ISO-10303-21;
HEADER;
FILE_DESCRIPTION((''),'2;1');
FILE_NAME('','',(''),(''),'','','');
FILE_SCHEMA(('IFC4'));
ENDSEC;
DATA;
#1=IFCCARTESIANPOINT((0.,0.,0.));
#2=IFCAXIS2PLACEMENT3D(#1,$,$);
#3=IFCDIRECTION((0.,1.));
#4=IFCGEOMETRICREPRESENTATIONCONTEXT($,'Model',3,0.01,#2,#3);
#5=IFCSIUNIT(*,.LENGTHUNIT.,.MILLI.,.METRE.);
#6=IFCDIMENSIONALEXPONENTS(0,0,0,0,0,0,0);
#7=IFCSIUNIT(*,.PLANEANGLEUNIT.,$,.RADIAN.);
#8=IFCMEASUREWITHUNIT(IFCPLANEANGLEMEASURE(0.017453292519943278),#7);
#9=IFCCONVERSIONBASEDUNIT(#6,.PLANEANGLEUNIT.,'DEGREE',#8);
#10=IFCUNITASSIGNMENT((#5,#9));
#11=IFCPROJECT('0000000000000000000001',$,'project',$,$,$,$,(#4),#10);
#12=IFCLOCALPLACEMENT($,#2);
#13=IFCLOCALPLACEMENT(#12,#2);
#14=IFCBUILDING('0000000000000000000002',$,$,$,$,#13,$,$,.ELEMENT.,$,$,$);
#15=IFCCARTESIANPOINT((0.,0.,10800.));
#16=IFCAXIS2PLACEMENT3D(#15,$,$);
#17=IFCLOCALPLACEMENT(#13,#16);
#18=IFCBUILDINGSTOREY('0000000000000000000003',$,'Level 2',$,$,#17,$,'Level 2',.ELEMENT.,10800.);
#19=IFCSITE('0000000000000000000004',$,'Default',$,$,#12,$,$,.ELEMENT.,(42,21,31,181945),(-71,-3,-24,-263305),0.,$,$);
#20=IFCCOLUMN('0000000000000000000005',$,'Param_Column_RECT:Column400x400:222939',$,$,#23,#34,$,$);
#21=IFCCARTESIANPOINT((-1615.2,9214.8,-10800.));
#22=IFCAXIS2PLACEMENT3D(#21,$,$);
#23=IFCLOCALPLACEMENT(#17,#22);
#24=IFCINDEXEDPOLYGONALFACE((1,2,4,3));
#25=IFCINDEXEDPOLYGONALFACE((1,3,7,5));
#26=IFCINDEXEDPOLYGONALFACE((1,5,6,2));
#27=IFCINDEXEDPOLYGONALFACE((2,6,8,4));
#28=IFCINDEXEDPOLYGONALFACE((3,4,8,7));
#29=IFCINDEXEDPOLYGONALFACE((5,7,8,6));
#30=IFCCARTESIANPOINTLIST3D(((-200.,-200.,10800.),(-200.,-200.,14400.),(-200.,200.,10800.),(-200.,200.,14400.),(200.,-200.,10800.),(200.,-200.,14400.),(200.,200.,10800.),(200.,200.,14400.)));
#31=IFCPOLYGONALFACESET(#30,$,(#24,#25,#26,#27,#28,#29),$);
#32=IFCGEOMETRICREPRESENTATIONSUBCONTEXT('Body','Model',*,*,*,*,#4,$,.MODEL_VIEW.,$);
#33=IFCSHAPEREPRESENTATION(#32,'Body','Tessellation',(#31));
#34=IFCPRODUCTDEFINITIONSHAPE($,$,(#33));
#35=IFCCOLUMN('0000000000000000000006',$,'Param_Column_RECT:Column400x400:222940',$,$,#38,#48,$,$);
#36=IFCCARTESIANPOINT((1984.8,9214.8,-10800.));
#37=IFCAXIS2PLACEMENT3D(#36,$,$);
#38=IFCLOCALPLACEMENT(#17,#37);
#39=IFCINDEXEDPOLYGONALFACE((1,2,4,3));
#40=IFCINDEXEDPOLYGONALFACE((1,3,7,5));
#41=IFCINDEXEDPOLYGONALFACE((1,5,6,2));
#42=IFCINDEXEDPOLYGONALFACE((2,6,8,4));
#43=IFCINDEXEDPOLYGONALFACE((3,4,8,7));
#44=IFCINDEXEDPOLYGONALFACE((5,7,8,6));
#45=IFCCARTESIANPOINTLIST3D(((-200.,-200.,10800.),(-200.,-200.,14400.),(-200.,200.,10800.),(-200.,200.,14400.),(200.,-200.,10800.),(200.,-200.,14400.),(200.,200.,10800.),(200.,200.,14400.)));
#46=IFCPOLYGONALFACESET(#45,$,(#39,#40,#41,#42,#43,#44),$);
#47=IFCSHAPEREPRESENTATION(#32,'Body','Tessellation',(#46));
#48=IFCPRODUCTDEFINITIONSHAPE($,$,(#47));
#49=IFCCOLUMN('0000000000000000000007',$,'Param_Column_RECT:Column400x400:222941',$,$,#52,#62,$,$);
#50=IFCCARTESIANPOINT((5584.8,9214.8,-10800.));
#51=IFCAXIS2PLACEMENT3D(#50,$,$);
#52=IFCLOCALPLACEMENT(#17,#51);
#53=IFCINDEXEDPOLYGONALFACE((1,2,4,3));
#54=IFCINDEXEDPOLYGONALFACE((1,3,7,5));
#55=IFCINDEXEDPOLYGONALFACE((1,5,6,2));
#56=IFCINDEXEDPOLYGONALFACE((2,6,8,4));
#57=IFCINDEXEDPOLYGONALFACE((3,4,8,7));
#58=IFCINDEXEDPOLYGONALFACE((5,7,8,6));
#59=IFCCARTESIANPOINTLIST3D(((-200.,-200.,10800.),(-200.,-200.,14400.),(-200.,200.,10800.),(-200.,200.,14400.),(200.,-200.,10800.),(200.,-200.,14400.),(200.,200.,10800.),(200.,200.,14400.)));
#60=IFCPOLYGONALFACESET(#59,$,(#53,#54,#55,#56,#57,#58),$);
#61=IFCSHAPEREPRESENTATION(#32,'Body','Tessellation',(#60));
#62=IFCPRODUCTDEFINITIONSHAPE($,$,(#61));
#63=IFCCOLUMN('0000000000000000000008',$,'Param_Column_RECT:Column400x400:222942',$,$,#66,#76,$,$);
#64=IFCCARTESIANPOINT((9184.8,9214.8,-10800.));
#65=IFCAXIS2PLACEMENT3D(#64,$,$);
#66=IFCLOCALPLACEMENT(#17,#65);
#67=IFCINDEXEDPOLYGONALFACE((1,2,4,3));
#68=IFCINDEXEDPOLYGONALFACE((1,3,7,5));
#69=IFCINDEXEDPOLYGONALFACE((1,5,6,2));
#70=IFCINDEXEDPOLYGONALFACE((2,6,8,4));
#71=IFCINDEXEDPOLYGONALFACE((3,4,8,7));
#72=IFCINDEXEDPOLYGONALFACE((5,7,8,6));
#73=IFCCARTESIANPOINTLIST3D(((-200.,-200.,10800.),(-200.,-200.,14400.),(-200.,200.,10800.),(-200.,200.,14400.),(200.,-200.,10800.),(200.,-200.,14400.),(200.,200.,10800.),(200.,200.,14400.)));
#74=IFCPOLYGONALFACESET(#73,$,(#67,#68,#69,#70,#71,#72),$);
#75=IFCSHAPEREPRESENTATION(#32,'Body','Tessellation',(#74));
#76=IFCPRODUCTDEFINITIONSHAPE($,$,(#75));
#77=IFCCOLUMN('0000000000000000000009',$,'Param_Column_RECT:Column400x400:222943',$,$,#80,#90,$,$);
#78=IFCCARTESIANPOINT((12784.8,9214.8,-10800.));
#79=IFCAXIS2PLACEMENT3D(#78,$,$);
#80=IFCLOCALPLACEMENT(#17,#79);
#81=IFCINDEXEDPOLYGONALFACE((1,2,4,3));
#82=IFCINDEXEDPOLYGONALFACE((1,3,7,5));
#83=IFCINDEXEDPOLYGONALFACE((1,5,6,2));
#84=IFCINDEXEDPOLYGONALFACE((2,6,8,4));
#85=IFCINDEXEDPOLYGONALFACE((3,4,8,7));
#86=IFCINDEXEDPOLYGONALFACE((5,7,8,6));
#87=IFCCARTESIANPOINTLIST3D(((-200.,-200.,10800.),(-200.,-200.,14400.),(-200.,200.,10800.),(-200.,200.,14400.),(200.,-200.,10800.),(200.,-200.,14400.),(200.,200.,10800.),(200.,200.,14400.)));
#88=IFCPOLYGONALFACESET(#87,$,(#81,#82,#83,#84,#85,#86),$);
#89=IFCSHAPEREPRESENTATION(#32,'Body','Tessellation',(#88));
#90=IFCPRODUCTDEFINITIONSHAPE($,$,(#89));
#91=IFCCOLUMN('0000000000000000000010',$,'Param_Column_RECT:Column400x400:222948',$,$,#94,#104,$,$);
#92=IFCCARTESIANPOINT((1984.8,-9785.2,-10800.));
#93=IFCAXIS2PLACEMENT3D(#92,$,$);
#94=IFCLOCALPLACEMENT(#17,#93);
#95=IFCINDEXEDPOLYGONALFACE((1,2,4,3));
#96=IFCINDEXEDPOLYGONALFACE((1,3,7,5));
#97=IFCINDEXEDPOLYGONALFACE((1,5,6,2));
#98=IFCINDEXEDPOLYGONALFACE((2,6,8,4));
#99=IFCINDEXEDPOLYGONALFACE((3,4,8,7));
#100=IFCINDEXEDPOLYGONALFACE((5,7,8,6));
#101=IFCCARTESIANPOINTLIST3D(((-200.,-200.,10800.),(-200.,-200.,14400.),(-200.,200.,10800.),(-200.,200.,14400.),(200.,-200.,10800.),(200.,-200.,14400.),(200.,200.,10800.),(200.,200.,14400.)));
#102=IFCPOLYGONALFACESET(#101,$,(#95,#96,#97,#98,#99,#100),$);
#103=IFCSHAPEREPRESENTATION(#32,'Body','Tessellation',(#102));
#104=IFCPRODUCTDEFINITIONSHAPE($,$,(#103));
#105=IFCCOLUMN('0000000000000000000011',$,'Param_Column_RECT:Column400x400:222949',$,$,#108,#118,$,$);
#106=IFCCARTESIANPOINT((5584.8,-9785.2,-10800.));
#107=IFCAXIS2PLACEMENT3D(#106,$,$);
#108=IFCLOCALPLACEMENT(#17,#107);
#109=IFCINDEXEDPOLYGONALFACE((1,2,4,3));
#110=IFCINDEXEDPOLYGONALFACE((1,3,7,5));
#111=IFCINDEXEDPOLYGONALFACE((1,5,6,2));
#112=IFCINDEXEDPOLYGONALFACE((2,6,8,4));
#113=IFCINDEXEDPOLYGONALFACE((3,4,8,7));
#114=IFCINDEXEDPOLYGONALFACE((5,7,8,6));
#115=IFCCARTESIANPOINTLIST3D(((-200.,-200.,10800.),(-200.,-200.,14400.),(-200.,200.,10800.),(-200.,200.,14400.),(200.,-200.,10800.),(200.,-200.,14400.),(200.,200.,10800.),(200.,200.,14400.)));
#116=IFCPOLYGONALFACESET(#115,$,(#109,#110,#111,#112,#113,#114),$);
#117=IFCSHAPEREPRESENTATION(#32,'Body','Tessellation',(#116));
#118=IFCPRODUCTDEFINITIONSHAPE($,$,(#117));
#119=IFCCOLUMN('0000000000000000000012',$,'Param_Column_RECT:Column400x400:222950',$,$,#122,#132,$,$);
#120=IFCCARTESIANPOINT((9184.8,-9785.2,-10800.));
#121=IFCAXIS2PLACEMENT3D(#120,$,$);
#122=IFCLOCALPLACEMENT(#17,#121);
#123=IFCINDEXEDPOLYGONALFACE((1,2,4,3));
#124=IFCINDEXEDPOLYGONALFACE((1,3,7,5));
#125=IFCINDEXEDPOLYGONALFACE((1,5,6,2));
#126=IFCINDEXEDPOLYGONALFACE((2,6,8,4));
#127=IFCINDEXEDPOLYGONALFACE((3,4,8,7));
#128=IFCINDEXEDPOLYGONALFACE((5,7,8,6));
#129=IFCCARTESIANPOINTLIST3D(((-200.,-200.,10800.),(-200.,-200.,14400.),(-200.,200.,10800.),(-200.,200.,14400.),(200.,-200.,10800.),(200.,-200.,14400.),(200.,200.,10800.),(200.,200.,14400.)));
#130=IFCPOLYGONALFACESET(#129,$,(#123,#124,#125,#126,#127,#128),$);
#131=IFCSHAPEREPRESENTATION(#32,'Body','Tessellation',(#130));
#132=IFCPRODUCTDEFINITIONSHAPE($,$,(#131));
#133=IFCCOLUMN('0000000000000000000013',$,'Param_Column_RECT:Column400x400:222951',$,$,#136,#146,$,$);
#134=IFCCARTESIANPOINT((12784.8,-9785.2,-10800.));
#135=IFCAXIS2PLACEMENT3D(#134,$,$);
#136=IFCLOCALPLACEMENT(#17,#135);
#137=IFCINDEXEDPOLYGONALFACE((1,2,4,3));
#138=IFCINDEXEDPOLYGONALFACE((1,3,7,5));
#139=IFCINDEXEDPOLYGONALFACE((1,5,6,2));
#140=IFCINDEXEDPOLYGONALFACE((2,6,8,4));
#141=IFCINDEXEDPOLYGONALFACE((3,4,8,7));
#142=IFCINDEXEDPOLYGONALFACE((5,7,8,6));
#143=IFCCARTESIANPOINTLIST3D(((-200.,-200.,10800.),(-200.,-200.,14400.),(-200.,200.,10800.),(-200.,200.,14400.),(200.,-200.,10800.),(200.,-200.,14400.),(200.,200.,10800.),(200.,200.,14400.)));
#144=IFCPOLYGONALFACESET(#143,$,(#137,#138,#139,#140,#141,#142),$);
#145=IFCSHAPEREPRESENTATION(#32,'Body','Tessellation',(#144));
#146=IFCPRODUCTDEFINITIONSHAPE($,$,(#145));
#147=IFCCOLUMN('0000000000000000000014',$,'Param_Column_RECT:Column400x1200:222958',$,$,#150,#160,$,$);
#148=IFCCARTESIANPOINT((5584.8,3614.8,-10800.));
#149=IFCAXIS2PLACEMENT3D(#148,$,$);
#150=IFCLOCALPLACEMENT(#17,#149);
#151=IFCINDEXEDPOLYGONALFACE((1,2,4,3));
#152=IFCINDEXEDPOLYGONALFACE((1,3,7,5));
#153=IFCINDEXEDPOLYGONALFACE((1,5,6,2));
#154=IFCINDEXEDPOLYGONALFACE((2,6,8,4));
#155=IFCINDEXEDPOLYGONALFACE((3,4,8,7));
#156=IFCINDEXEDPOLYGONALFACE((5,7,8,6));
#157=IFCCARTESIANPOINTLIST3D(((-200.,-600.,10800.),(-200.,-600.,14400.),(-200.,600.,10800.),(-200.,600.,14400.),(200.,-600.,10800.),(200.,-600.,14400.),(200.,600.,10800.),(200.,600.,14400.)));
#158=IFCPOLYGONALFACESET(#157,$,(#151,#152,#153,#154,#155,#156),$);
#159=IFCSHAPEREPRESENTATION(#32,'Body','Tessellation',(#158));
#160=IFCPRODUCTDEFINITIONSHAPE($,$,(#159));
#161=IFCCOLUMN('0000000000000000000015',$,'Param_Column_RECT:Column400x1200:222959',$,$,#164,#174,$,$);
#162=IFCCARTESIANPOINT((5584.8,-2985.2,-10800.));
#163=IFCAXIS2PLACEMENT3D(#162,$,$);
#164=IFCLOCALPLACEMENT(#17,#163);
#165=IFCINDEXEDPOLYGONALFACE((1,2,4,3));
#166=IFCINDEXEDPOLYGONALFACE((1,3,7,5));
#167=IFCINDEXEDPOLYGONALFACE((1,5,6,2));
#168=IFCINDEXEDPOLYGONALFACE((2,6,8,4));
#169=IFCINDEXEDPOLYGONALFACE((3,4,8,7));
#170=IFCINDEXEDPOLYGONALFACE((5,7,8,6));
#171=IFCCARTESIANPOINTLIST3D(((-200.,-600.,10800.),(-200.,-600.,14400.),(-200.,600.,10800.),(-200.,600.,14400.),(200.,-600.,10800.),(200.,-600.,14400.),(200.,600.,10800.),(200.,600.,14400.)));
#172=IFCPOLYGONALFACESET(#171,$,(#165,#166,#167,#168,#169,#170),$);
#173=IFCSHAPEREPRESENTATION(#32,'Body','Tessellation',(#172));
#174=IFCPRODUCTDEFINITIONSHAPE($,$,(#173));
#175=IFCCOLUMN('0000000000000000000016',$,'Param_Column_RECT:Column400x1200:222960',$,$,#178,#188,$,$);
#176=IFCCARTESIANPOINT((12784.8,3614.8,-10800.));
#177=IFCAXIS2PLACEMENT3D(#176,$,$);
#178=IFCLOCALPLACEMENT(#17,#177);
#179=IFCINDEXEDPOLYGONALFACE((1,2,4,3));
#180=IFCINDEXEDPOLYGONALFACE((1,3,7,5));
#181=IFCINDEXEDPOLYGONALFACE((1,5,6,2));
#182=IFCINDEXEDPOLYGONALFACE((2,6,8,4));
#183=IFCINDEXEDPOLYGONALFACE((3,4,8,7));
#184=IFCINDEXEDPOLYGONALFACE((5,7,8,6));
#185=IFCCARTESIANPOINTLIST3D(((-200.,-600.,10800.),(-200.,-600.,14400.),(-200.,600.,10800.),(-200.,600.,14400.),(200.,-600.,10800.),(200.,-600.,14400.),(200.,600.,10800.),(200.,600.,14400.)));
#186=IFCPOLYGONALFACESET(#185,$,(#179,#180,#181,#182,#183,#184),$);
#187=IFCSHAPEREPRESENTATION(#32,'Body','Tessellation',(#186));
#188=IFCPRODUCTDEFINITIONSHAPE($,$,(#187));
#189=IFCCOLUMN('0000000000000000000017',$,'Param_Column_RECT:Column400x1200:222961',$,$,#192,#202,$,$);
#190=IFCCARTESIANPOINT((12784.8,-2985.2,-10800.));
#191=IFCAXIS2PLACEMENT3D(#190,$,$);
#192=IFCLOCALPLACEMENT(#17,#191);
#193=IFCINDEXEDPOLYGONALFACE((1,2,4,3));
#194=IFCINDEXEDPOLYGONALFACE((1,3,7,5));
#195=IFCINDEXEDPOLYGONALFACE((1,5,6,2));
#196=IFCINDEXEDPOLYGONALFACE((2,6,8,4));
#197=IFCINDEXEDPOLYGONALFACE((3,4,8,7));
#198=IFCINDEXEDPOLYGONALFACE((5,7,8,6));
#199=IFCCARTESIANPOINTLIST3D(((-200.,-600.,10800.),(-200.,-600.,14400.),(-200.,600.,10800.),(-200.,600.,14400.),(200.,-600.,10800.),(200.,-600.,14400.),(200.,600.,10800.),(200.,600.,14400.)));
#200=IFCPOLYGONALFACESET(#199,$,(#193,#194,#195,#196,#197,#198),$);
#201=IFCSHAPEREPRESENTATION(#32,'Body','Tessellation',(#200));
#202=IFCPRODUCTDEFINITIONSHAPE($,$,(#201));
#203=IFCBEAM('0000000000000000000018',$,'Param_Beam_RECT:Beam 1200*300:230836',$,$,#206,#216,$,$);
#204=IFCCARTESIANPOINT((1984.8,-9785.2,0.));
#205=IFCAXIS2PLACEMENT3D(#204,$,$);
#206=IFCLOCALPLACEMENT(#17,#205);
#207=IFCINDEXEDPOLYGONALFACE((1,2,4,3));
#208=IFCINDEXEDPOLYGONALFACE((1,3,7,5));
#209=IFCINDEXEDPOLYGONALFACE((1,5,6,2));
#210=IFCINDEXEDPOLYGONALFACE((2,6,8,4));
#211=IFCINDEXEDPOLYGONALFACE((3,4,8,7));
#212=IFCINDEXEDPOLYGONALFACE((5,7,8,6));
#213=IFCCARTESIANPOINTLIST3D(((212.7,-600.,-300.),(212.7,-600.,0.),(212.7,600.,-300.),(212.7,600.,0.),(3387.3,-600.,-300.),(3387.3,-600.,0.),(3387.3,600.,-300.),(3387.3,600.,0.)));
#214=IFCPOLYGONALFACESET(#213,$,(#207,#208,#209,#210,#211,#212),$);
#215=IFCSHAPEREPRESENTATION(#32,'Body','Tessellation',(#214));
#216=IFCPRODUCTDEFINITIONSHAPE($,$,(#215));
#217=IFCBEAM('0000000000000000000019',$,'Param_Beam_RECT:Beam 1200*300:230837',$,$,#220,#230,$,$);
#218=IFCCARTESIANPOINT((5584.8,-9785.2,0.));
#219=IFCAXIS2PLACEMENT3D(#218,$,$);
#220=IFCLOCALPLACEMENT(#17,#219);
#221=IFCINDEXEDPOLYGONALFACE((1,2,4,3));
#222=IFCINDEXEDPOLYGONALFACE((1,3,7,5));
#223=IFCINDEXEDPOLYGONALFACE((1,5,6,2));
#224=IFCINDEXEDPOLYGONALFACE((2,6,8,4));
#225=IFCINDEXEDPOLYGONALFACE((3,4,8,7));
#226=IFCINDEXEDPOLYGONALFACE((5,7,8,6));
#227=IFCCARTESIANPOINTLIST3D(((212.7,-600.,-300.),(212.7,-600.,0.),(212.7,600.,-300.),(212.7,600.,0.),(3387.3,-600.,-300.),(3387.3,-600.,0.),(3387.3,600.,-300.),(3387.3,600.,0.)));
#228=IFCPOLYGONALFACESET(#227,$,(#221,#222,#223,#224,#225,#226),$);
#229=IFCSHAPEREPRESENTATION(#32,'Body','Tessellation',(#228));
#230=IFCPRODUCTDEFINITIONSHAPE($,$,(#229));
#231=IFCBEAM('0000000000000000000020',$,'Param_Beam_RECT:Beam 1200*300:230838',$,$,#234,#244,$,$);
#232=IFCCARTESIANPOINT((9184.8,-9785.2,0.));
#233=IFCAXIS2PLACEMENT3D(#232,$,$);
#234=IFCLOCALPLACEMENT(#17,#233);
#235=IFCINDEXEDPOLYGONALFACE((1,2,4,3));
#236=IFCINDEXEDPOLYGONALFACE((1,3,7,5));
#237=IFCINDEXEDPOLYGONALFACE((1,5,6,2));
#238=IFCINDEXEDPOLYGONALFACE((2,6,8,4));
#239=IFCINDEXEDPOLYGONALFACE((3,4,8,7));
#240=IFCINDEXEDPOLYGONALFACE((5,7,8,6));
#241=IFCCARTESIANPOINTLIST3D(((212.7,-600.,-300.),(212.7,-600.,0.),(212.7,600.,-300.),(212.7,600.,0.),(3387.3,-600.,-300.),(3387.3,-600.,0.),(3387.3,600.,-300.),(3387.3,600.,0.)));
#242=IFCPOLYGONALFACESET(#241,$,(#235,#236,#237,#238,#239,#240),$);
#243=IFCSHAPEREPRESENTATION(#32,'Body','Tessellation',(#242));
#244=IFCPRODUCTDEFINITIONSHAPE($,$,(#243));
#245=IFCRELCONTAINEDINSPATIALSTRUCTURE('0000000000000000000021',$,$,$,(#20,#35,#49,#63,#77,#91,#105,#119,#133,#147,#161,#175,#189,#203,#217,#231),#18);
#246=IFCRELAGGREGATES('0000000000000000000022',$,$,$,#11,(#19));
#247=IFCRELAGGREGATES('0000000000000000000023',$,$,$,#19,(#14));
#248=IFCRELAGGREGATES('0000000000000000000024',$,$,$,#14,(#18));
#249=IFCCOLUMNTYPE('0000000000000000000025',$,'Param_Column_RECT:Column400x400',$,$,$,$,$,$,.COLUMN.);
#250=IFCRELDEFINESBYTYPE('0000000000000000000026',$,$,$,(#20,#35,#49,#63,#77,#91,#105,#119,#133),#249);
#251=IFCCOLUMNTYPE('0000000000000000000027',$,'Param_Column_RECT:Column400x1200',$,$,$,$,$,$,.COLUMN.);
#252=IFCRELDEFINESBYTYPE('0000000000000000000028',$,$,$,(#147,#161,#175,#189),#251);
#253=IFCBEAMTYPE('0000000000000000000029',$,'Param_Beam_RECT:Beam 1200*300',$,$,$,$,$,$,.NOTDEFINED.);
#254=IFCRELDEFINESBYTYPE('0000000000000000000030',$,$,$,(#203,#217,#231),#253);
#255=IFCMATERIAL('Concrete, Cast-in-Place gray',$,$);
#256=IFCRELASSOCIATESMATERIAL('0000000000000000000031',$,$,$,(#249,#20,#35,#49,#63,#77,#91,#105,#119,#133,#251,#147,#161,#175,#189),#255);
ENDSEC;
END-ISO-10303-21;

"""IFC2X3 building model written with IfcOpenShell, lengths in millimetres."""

from ifc_helpers import new_model, entity, si_unit, converted_unit, direction, frame, frame_2d, origin, origin_2d_with_axis, place, context, subcontext, project, spatial, rectangle, extrude, source, transform, mapped, material, type_object, type_shapes, element, save


model = new_model("IFC2X3")

# Units and contexts
model_context = context("Model", 3, precision=0.01, world=origin(), true_north=direction((0.0, 1.0)))
body_context = subcontext(model_context, "Body", "Model", "MODEL_VIEW")
ifc_project = project(units=[si_unit("LENGTHUNIT", "METRE", prefix="MILLI"), converted_unit("PLANEANGLEUNIT", "DEGREE", entity("IfcPlaneAngleMeasure", 0.017453292519943278), si_unit("PLANEANGLEUNIT", "RADIAN"), dimensions=[0, 0, 0, 0, 0, 0, 0])], contexts=[model_context])

# Site, building, storey
site_placement = place(None, origin())
site = spatial("IfcSite", under=ifc_project, at=site_placement, Name="Default", CompositionType="ELEMENT", RefLatitude=(42, 21, 31, 181945), RefLongitude=(-71, -3, -24, -263305), RefElevation=0.0)
building_placement = place(site_placement, origin())
building = spatial("IfcBuilding", under=site, at=building_placement, CompositionType="ELEMENT")
storey_placement = place(building_placement, frame((0.0, 0.0, 10800.0)))
storey = spatial("IfcBuildingStorey", under=building, at=storey_placement, Name="Level 2", LongName="Level 2", CompositionType="ELEMENT", Elevation=10800.0)

# Columns
ifc_material_1 = material(Name="Concrete, Cast-in-Place gray")
column_type_1 = type_object("IfcColumnType", Name="Param_Column_RECT:Column400x400", PredefinedType="COLUMN", material=ifc_material_1)
shared_shape_1 = source(origin(), body_context, "Body", "SweptSolid", [
    extrude(rectangle(XDim=400.0, YDim=400.0, at=origin_2d_with_axis()), frame((0.0, 0.0, 10800.0), z_axis=(0.0, 0.0, 1.0), x_axis=(-1.0, 0.0, 0.0)), (0.0, 0.0, 1.0), 3600.0),
])
type_shapes(column_type_1, [shared_shape_1])
for number, where, name in (
    (1, (-1615.2, 9214.8, -10800.0), "Param_Column_RECT:Column400x400:222939"),
    (2, (1984.8, 9214.8, -10800.0), "Param_Column_RECT:Column400x400:222940"),
    (3, (5584.8, 9214.8, -10800.0), "Param_Column_RECT:Column400x400:222941"),
    (4, (9184.8, 9214.8, -10800.0), "Param_Column_RECT:Column400x400:222942"),
    (5, (12784.8, 9214.8, -10800.0), "Param_Column_RECT:Column400x400:222943"),
    (6, (1984.8, -9785.2, -10800.0), "Param_Column_RECT:Column400x400:222948"),
    (7, (5584.8, -9785.2, -10800.0), "Param_Column_RECT:Column400x400:222949"),
    (8, (9184.8, -9785.2, -10800.0), "Param_Column_RECT:Column400x400:222950"),
    (9, (12784.8, -9785.2, -10800.0), "Param_Column_RECT:Column400x400:222951"),
):
    element("IfcColumn", number, at=place(storey_placement, frame(where)), inside=storey, type_object=column_type_1, material=ifc_material_1, Name=name, context=body_context, shape_type="MappedRepresentation", body=[
        mapped(shared_shape_1, transform((0.0, 0.0, 0.0), scale=1.0)),
    ])
column_type_2 = type_object("IfcColumnType", Name="Param_Column_RECT:Column400x1200", PredefinedType="COLUMN", material=ifc_material_1)
shared_shape_2 = source(origin(), body_context, "Body", "SweptSolid", [
    extrude(rectangle(XDim=400.0, YDim=1200.0, at=origin_2d_with_axis()), frame((0.0, 0.0, 10800.0), z_axis=(0.0, 0.0, 1.0), x_axis=(-1.0, 0.0, 0.0)), (0.0, 0.0, 1.0), 3600.0),
])
type_shapes(column_type_2, [shared_shape_2])
for number, where, name in (
    (10, (5584.8, 3614.8, -10800.0), "Param_Column_RECT:Column400x1200:222958"),
    (11, (5584.8, -2985.2, -10800.0), "Param_Column_RECT:Column400x1200:222959"),
    (12, (12784.8, 3614.8, -10800.0), "Param_Column_RECT:Column400x1200:222960"),
    (13, (12784.8, -2985.2, -10800.0), "Param_Column_RECT:Column400x1200:222961"),
):
    element("IfcColumn", number, at=place(storey_placement, frame(where)), inside=storey, type_object=column_type_2, material=ifc_material_1, Name=name, context=body_context, shape_type="MappedRepresentation", body=[
        mapped(shared_shape_2, transform((0.0, 0.0, 0.0), scale=1.0)),
    ])

# Beams
beam_type_1 = type_object("IfcBeamType", Name="Param_Beam_RECT:Beam 1200*300", PredefinedType="NOTDEFINED")
beam_1_placement = place(storey_placement, frame((1984.8, -9785.2, 0.0)))
element("IfcBeam", 14, at=beam_1_placement, inside=storey, type_object=beam_type_1, Name="Param_Beam_RECT:Beam 1200*300:230836", context=body_context, shape_type="SweptSolid", body=[
    extrude(rectangle(XDim=300.0, YDim=1200.0, at=origin_2d_with_axis()), frame((212.7, 0.0, -150.0), z_axis=(1.0, 0.0, 0.0), x_axis=(0.0, 0.0, -1.0)), (0.0, 0.0, 1.0), 3174.6),
])
for number, where, name in (
    (15, (5584.8, -9785.2, 0.0), "Param_Beam_RECT:Beam 1200*300:230837"),
    (16, (9184.8, -9785.2, 0.0), "Param_Beam_RECT:Beam 1200*300:230838"),
):
    element("IfcBeam", number, at=place(storey_placement, frame(where)), inside=storey, type_object=beam_type_1, Name=name, context=body_context, shape_type="SweptSolid", body=[
        extrude(rectangle(XDim=300.0, YDim=1200.0, at=frame_2d((0.0, 0.0), x_axis=(1.0, 0.0))), frame((212.7, 0.0, -150.0), z_axis=(1.0, 0.0, 0.0), x_axis=(0.0, 0.0, -1.0)), (0.0, 0.0, 1.0), 3174.6),
    ])

save(model, "model.ifc")
